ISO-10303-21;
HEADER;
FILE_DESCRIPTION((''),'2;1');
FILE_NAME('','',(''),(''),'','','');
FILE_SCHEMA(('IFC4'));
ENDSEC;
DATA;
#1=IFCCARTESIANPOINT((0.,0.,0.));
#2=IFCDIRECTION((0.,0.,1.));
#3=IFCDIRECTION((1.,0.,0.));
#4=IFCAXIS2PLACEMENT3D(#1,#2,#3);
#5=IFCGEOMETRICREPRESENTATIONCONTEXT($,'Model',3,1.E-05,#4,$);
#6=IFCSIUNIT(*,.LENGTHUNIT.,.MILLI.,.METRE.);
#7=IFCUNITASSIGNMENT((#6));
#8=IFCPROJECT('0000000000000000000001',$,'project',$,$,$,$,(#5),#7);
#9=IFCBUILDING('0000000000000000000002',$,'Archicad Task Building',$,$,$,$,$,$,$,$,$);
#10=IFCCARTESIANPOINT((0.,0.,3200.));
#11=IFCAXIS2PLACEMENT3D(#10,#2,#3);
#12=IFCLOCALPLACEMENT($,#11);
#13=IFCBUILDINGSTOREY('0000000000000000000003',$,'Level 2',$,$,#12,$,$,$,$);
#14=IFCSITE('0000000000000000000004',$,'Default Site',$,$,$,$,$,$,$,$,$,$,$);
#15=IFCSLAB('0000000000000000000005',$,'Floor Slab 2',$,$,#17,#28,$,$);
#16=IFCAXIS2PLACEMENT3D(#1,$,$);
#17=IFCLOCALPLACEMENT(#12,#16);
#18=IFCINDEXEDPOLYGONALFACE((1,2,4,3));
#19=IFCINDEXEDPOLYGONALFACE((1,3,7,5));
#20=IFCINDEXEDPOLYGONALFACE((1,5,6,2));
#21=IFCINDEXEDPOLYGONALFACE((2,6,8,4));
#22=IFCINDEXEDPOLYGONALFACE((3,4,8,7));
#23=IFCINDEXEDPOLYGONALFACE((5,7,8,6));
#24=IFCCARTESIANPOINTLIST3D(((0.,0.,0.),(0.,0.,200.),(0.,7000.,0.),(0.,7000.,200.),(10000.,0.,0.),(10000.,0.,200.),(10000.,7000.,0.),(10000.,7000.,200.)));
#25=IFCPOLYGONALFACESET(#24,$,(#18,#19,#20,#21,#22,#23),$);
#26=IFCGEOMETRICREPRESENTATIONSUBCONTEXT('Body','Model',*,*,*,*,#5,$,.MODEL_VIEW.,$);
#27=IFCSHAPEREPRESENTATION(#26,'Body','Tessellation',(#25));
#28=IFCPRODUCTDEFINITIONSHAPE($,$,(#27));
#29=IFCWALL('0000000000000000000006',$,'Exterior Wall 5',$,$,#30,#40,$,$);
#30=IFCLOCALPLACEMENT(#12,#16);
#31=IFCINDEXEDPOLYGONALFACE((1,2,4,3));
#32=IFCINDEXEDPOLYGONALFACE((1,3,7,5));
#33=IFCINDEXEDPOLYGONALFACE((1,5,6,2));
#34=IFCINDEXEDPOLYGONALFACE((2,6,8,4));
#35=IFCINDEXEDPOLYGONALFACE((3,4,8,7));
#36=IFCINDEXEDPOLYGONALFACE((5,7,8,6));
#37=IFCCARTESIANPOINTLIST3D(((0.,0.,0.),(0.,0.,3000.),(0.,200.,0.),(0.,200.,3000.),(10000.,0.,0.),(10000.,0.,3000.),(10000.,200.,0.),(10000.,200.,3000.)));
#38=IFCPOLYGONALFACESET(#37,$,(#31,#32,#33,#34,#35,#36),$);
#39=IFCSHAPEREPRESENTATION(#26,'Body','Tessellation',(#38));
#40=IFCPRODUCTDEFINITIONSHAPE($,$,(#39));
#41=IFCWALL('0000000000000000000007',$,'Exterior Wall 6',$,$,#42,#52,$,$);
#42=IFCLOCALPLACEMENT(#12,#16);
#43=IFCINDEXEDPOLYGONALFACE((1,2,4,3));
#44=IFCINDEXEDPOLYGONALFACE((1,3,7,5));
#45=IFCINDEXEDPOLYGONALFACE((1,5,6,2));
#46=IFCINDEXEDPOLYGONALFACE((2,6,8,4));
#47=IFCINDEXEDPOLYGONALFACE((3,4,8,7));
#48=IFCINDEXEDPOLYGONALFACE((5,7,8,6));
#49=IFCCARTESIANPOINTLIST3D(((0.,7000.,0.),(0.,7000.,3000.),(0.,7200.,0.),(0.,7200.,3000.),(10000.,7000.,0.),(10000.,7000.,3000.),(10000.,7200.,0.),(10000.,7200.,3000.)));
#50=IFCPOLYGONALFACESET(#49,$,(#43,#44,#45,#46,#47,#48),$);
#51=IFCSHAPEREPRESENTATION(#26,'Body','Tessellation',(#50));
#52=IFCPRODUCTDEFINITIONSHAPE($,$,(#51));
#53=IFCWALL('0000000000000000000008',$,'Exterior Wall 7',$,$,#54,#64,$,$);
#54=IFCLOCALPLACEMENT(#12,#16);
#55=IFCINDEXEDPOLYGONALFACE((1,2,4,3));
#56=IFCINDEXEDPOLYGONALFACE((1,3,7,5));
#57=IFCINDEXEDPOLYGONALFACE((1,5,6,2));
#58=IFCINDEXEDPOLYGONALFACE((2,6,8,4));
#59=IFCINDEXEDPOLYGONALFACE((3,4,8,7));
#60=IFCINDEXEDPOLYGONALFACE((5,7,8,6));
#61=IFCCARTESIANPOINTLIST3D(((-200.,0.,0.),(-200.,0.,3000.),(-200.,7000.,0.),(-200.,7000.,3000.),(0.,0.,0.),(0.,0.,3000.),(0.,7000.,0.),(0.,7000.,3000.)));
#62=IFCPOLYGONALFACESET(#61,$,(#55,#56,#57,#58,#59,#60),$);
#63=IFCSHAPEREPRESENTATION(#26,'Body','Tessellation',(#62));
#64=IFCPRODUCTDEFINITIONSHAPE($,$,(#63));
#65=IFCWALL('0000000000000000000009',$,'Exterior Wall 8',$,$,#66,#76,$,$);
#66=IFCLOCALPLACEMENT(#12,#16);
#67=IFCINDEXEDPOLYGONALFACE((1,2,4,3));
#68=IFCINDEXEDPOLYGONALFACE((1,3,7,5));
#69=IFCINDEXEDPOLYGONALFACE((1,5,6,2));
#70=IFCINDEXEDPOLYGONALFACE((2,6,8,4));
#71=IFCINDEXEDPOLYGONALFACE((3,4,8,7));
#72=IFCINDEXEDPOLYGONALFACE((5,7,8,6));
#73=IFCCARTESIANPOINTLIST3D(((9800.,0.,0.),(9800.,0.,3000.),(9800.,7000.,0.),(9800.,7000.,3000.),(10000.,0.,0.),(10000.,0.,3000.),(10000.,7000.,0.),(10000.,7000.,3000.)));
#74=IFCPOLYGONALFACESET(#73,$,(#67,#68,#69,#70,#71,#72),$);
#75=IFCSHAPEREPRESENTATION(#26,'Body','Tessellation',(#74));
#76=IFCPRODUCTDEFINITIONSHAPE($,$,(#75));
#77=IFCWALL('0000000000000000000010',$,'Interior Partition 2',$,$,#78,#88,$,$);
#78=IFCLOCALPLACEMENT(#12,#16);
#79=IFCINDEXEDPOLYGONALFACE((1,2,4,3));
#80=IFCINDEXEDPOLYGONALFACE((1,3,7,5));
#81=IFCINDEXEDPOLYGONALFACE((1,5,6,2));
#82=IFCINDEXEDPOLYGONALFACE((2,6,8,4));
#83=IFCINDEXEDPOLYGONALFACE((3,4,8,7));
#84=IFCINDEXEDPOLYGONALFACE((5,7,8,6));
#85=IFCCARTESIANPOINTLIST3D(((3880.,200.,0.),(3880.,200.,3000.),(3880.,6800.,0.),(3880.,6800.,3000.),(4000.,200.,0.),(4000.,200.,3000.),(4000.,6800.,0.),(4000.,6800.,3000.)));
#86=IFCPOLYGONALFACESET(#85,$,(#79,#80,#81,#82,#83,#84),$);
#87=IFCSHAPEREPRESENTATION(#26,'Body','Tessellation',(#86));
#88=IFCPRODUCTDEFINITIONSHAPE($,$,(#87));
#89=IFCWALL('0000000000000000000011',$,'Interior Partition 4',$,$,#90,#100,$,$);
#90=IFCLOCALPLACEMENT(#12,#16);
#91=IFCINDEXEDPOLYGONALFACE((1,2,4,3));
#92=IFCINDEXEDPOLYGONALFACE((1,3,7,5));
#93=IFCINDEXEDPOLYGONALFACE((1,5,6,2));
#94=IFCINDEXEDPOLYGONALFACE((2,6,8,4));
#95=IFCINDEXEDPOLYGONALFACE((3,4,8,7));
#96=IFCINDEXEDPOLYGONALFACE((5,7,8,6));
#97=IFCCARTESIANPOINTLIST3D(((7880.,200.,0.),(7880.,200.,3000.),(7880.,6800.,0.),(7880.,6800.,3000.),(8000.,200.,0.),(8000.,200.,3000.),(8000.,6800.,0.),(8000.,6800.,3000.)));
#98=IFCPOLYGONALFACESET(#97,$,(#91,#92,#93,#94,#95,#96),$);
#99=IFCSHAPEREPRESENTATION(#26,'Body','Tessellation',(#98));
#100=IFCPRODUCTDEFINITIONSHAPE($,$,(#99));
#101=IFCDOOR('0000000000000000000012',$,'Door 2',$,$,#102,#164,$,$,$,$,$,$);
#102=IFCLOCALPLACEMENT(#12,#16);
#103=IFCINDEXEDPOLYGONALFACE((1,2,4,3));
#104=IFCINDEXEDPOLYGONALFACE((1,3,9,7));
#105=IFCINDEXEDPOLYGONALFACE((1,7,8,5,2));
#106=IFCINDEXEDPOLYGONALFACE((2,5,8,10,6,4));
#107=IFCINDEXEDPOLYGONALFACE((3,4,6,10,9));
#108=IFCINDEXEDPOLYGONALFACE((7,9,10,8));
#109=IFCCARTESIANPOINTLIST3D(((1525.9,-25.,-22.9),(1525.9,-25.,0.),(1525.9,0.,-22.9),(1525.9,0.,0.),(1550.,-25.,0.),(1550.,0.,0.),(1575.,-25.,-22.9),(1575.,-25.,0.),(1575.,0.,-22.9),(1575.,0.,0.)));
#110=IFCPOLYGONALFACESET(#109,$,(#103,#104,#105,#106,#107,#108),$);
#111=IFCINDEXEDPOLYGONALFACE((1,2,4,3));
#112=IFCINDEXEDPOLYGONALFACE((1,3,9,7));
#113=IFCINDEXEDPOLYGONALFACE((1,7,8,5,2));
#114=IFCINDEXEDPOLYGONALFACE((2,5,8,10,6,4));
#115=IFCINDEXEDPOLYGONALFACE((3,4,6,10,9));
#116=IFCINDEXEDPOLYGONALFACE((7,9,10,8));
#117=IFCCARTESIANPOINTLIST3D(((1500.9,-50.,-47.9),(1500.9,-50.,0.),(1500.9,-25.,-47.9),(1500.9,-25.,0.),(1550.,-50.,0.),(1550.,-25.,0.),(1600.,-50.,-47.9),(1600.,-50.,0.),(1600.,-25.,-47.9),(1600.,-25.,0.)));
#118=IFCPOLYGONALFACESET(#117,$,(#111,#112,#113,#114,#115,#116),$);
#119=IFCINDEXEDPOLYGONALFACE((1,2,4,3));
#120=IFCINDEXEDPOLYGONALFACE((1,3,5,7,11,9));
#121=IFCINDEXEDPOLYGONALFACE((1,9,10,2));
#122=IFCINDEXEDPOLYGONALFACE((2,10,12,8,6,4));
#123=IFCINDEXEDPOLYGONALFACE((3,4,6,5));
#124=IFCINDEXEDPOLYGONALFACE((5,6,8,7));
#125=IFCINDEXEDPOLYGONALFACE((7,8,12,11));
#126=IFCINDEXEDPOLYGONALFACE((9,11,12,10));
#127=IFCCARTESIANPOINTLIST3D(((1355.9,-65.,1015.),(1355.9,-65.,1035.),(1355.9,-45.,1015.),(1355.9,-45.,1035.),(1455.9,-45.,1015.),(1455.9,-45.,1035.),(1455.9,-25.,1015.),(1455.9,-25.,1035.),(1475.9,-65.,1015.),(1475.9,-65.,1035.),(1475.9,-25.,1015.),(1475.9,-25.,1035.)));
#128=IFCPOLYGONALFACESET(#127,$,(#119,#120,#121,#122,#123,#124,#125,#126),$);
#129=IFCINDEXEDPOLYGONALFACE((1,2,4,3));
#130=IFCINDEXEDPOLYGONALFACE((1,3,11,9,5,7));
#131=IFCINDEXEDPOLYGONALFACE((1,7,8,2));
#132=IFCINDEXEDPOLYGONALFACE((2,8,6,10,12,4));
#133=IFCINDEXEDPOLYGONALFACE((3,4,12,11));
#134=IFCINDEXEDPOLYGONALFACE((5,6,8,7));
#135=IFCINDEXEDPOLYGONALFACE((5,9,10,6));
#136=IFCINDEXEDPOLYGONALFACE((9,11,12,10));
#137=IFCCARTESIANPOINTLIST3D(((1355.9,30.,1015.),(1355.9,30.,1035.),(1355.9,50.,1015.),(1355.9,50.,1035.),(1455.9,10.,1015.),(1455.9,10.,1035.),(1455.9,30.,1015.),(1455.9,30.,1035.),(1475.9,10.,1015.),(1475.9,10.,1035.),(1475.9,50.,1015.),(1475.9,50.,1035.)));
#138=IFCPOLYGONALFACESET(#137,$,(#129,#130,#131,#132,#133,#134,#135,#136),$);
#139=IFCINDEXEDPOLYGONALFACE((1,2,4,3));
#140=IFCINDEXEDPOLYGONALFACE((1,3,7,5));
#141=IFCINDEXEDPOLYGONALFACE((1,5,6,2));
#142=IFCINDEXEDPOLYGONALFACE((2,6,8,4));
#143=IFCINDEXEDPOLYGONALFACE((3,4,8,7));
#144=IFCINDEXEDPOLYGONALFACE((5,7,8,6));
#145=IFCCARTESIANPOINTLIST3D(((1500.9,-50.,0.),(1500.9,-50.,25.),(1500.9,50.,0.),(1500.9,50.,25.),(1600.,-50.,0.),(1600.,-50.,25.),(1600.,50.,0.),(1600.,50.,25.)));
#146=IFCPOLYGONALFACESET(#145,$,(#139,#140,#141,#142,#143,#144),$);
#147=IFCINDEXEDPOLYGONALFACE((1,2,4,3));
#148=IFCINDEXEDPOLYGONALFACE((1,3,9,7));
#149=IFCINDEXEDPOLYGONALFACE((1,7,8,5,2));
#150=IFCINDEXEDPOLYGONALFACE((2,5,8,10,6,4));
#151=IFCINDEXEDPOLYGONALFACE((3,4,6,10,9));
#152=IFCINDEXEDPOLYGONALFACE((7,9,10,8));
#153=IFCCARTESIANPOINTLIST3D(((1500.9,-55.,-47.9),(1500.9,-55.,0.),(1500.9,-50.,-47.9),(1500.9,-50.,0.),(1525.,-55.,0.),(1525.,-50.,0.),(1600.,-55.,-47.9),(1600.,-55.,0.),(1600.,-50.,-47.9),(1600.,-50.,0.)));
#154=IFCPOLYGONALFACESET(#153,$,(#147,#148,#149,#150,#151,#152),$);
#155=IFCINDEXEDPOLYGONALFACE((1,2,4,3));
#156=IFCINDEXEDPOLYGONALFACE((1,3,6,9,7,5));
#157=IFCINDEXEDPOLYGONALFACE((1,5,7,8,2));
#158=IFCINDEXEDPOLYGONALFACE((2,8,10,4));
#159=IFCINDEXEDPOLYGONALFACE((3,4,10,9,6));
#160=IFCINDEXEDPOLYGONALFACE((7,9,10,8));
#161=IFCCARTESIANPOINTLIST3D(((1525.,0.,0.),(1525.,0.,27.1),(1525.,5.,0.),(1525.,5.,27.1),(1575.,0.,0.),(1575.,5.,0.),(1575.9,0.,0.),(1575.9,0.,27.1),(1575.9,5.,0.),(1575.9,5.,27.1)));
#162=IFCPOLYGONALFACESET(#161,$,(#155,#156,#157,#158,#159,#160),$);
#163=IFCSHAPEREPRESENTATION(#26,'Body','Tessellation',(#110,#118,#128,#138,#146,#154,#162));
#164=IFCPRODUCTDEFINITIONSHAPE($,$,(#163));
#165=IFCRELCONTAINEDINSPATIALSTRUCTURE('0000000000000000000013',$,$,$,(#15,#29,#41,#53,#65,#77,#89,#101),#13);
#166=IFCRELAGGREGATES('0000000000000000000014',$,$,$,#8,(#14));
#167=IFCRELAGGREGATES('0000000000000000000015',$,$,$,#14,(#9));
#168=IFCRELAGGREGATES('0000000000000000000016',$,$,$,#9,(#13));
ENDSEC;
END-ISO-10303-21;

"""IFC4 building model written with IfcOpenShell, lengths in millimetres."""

from ifc_helpers import new_model, si_unit, frame, origin_with_axes, place, context, subcontext, project, spatial, line, indexed_curve, outline, extrude, element, save


model = new_model("IFC4")

# Units and contexts
model_context = context("Model", 3, precision=1e-05, world=origin_with_axes())
body_context = subcontext(model_context, "Body", "Model", "MODEL_VIEW")
ifc_project = project(units=[si_unit("LENGTHUNIT", "METRE", prefix="MILLI")], contexts=[model_context])

# Site, building, storey
site = spatial("IfcSite", under=ifc_project, Name="Default Site")
building = spatial("IfcBuilding", under=site, Name="Archicad Task Building")
storey_placement = place(None, frame((0.0, 0.0, 3200.0), z_axis=(0.0, 0.0, 1.0), x_axis=(1.0, 0.0, 0.0)))
storey = spatial("IfcBuildingStorey", under=building, at=storey_placement, Name="Level 2")

# Slab
slab_placement = place(storey_placement, origin_with_axes())
element("IfcSlab", 1, at=slab_placement, inside=storey, Name="Floor Slab 2", context=body_context, shape_type="SweptSolid", body=[
    extrude(outline(indexed_curve([(0.0, 0.0), (10000.0, 0.0), (10000.0, 7000.0), (0.0, 7000.0), (0.0, 0.0)])), None, (0.0, 0.0, 1.0), 200.0),
])

# Walls
for number, where, z_axis, x_axis, name in (
    (2, (0.0, 0.0, 0.0), (0.0, 0.0, 1.0), (1.0, 0.0, 0.0), "Exterior Wall 5"),
    (3, (0.0, 7000.0, 0.0), (0.0, 0.0, 1.0), (1.0, 0.0, 0.0), "Exterior Wall 6"),
):
    element("IfcWall", number, at=place(storey_placement, frame(where, z_axis=z_axis, x_axis=x_axis)), inside=storey, Name=name, context=body_context, shape_type="SweptSolid", body=[
        extrude(outline(indexed_curve([(0.0, 0.0), (0.0, 200.0), (10000.0, 200.0), (10000.0, 0.0), (0.0, 0.0)], self_intersect=False)), origin_with_axes(), (0.0, 0.0, 1.0), 3000.0),
    ])
for number, where, z_axis, x_axis, name in (
    (4, (0.0, 0.0, 0.0), (0.0, 0.0, 1.0), (0.0, 1.0, 0.0), "Exterior Wall 7"),
    (5, (10000.0, 0.0, 0.0), (0.0, 0.0, 1.0), (0.0, 1.0, 0.0), "Exterior Wall 8"),
):
    element("IfcWall", number, at=place(storey_placement, frame(where, z_axis=z_axis, x_axis=x_axis)), inside=storey, Name=name, context=body_context, shape_type="SweptSolid", body=[
        extrude(outline(indexed_curve([(0.0, 0.0), (0.0, 200.0), (7000.0, 200.0), (7000.0, 0.0), (0.0, 0.0)], self_intersect=False)), origin_with_axes(), (0.0, 0.0, 1.0), 3000.0),
    ])
for number, where, z_axis, x_axis, name in (
    (6, (4000.0, 200.0, 0.0), (0.0, 0.0, 1.0), (0.0, 1.0, 0.0), "Interior Partition 2"),
    (7, (8000.0, 200.0, 0.0), (0.0, 0.0, 1.0), (0.0, 1.0, 0.0), "Interior Partition 4"),
):
    element("IfcWall", number, at=place(storey_placement, frame(where, z_axis=z_axis, x_axis=x_axis)), inside=storey, Name=name, context=body_context, shape_type="SweptSolid", body=[
        extrude(outline(indexed_curve([(0.0, 0.0), (0.0, 120.0), (6600.0, 120.0), (6600.0, 0.0), (0.0, 0.0)], self_intersect=False)), origin_with_axes(), (0.0, 0.0, 1.0), 3000.0),
    ])

# Door
door_1_placement = place(storey_placement, frame((1550.0, -50.0, 0.0), z_axis=(0.0, 0.0, 1.0), x_axis=(1.0, 0.0, 0.0)))
element("IfcDoor", 8, at=door_1_placement, inside=storey, Name="Door 2", context=body_context, shape_type="SweptSolid", body=[
    extrude(outline(indexed_curve([(0.0, 0.0), (0.0, 2.1), (0.9, 2.1), (0.9, 0.0), (-24.1, 0.0), (-24.1, -22.9), (25.0, -22.9), (25.0, 0.0)], segments=[line(1, 2, 3, 4, 5, 6, 7, 8, 1)])), frame((0.0, 25.0, 0.0), z_axis=(0.0, -1.0, 0.0), x_axis=(1.0, 0.0, 0.0)), (0.0, 0.0, -1.0), 25.0),
    extrude(outline(indexed_curve([(0.0, 0.0), (0.0, 2.1), (0.9, 2.1), (0.9, 0.0), (-49.1, 0.0), (-49.1, -47.9), (50.0, -47.9), (50.0, 0.0)], segments=[line(1, 2, 3, 4, 5, 6, 7, 8, 1)])), frame((0.0, 0.0, 0.0), z_axis=(0.0, -1.0, 0.0), x_axis=(1.0, 0.0, 0.0)), (0.0, 0.0, -1.0), 25.0),
    extrude(outline(indexed_curve([(0.0, 0.0), (-49.1, 0.0), (-49.1, 35.0), (0.0, 35.0)], segments=[line(1, 2, 3, 4, 1)])), frame((25.0, 25.0, 25.0), z_axis=(0.0, 0.0, 1.0), x_axis=(1.0, 0.0, 0.0)), (0.0, 0.0, 1.0), -47.9),
    extrude(outline(indexed_curve([(0.0, 0.0), (0.0, -40.0), (-120.0, -40.0), (-120.0, -20.0), (-20.0, -20.0), (-20.0, 0.0)], segments=[line(1, 2, 3, 4, 5, 6, 1)])), frame((-74.1, 25.0, 1015.0), z_axis=(0.0, 0.0, 1.0), x_axis=(1.0, 0.0, 0.0)), (0.0, 0.0, 1.0), 20.0),
    extrude(outline(indexed_curve([(0.0, 0.0), (0.0, 40.0), (-120.0, 40.0), (-120.0, 20.0), (-20.0, 20.0), (-20.0, 0.0)], segments=[line(1, 2, 3, 4, 5, 6, 1)])), frame((-74.1, 60.0, 1015.0), z_axis=(0.0, 0.0, 1.0), x_axis=(1.0, 0.0, 0.0)), (0.0, 0.0, 1.0), 20.0),
    extrude(outline(indexed_curve([(0.0, 0.0), (-99.1, 0.0), (-99.1, 100.0), (0.0, 100.0)], segments=[line(1, 2, 3, 4, 1)])), frame((50.0, 0.0, 0.0), z_axis=(0.0, 0.0, 1.0), x_axis=(1.0, 0.0, 0.0)), (0.0, 0.0, 1.0), 25.0),
    extrude(outline(indexed_curve([(0.0, 0.0), (0.0, 27.1), (50.9, 27.1), (50.9, 0.0), (-24.1, 0.0), (-24.1, -47.9), (75.0, -47.9), (75.0, 0.0)], segments=[line(1, 2, 3, 4, 5, 6, 7, 8, 1)])), frame((-25.0, -5.0, 0.0), z_axis=(0.0, -1.0, 0.0), x_axis=(1.0, 0.0, 0.0)), (0.0, 0.0, -1.0), 5.0),
    extrude(outline(indexed_curve([(0.0, 0.0), (0.0, 27.1), (50.9, 27.1), (50.9, 0.0), (0.9, 0.0), (0.9, -22.9), (50.0, -22.9), (50.0, 0.0)], segments=[line(1, 2, 3, 4, 5, 6, 7, 8, 1)])), frame((-25.0, 50.0, 0.0), z_axis=(0.0, -1.0, 0.0), x_axis=(1.0, 0.0, 0.0)), (0.0, 0.0, -1.0), 5.0),
])

save(model, "model.ifc")
